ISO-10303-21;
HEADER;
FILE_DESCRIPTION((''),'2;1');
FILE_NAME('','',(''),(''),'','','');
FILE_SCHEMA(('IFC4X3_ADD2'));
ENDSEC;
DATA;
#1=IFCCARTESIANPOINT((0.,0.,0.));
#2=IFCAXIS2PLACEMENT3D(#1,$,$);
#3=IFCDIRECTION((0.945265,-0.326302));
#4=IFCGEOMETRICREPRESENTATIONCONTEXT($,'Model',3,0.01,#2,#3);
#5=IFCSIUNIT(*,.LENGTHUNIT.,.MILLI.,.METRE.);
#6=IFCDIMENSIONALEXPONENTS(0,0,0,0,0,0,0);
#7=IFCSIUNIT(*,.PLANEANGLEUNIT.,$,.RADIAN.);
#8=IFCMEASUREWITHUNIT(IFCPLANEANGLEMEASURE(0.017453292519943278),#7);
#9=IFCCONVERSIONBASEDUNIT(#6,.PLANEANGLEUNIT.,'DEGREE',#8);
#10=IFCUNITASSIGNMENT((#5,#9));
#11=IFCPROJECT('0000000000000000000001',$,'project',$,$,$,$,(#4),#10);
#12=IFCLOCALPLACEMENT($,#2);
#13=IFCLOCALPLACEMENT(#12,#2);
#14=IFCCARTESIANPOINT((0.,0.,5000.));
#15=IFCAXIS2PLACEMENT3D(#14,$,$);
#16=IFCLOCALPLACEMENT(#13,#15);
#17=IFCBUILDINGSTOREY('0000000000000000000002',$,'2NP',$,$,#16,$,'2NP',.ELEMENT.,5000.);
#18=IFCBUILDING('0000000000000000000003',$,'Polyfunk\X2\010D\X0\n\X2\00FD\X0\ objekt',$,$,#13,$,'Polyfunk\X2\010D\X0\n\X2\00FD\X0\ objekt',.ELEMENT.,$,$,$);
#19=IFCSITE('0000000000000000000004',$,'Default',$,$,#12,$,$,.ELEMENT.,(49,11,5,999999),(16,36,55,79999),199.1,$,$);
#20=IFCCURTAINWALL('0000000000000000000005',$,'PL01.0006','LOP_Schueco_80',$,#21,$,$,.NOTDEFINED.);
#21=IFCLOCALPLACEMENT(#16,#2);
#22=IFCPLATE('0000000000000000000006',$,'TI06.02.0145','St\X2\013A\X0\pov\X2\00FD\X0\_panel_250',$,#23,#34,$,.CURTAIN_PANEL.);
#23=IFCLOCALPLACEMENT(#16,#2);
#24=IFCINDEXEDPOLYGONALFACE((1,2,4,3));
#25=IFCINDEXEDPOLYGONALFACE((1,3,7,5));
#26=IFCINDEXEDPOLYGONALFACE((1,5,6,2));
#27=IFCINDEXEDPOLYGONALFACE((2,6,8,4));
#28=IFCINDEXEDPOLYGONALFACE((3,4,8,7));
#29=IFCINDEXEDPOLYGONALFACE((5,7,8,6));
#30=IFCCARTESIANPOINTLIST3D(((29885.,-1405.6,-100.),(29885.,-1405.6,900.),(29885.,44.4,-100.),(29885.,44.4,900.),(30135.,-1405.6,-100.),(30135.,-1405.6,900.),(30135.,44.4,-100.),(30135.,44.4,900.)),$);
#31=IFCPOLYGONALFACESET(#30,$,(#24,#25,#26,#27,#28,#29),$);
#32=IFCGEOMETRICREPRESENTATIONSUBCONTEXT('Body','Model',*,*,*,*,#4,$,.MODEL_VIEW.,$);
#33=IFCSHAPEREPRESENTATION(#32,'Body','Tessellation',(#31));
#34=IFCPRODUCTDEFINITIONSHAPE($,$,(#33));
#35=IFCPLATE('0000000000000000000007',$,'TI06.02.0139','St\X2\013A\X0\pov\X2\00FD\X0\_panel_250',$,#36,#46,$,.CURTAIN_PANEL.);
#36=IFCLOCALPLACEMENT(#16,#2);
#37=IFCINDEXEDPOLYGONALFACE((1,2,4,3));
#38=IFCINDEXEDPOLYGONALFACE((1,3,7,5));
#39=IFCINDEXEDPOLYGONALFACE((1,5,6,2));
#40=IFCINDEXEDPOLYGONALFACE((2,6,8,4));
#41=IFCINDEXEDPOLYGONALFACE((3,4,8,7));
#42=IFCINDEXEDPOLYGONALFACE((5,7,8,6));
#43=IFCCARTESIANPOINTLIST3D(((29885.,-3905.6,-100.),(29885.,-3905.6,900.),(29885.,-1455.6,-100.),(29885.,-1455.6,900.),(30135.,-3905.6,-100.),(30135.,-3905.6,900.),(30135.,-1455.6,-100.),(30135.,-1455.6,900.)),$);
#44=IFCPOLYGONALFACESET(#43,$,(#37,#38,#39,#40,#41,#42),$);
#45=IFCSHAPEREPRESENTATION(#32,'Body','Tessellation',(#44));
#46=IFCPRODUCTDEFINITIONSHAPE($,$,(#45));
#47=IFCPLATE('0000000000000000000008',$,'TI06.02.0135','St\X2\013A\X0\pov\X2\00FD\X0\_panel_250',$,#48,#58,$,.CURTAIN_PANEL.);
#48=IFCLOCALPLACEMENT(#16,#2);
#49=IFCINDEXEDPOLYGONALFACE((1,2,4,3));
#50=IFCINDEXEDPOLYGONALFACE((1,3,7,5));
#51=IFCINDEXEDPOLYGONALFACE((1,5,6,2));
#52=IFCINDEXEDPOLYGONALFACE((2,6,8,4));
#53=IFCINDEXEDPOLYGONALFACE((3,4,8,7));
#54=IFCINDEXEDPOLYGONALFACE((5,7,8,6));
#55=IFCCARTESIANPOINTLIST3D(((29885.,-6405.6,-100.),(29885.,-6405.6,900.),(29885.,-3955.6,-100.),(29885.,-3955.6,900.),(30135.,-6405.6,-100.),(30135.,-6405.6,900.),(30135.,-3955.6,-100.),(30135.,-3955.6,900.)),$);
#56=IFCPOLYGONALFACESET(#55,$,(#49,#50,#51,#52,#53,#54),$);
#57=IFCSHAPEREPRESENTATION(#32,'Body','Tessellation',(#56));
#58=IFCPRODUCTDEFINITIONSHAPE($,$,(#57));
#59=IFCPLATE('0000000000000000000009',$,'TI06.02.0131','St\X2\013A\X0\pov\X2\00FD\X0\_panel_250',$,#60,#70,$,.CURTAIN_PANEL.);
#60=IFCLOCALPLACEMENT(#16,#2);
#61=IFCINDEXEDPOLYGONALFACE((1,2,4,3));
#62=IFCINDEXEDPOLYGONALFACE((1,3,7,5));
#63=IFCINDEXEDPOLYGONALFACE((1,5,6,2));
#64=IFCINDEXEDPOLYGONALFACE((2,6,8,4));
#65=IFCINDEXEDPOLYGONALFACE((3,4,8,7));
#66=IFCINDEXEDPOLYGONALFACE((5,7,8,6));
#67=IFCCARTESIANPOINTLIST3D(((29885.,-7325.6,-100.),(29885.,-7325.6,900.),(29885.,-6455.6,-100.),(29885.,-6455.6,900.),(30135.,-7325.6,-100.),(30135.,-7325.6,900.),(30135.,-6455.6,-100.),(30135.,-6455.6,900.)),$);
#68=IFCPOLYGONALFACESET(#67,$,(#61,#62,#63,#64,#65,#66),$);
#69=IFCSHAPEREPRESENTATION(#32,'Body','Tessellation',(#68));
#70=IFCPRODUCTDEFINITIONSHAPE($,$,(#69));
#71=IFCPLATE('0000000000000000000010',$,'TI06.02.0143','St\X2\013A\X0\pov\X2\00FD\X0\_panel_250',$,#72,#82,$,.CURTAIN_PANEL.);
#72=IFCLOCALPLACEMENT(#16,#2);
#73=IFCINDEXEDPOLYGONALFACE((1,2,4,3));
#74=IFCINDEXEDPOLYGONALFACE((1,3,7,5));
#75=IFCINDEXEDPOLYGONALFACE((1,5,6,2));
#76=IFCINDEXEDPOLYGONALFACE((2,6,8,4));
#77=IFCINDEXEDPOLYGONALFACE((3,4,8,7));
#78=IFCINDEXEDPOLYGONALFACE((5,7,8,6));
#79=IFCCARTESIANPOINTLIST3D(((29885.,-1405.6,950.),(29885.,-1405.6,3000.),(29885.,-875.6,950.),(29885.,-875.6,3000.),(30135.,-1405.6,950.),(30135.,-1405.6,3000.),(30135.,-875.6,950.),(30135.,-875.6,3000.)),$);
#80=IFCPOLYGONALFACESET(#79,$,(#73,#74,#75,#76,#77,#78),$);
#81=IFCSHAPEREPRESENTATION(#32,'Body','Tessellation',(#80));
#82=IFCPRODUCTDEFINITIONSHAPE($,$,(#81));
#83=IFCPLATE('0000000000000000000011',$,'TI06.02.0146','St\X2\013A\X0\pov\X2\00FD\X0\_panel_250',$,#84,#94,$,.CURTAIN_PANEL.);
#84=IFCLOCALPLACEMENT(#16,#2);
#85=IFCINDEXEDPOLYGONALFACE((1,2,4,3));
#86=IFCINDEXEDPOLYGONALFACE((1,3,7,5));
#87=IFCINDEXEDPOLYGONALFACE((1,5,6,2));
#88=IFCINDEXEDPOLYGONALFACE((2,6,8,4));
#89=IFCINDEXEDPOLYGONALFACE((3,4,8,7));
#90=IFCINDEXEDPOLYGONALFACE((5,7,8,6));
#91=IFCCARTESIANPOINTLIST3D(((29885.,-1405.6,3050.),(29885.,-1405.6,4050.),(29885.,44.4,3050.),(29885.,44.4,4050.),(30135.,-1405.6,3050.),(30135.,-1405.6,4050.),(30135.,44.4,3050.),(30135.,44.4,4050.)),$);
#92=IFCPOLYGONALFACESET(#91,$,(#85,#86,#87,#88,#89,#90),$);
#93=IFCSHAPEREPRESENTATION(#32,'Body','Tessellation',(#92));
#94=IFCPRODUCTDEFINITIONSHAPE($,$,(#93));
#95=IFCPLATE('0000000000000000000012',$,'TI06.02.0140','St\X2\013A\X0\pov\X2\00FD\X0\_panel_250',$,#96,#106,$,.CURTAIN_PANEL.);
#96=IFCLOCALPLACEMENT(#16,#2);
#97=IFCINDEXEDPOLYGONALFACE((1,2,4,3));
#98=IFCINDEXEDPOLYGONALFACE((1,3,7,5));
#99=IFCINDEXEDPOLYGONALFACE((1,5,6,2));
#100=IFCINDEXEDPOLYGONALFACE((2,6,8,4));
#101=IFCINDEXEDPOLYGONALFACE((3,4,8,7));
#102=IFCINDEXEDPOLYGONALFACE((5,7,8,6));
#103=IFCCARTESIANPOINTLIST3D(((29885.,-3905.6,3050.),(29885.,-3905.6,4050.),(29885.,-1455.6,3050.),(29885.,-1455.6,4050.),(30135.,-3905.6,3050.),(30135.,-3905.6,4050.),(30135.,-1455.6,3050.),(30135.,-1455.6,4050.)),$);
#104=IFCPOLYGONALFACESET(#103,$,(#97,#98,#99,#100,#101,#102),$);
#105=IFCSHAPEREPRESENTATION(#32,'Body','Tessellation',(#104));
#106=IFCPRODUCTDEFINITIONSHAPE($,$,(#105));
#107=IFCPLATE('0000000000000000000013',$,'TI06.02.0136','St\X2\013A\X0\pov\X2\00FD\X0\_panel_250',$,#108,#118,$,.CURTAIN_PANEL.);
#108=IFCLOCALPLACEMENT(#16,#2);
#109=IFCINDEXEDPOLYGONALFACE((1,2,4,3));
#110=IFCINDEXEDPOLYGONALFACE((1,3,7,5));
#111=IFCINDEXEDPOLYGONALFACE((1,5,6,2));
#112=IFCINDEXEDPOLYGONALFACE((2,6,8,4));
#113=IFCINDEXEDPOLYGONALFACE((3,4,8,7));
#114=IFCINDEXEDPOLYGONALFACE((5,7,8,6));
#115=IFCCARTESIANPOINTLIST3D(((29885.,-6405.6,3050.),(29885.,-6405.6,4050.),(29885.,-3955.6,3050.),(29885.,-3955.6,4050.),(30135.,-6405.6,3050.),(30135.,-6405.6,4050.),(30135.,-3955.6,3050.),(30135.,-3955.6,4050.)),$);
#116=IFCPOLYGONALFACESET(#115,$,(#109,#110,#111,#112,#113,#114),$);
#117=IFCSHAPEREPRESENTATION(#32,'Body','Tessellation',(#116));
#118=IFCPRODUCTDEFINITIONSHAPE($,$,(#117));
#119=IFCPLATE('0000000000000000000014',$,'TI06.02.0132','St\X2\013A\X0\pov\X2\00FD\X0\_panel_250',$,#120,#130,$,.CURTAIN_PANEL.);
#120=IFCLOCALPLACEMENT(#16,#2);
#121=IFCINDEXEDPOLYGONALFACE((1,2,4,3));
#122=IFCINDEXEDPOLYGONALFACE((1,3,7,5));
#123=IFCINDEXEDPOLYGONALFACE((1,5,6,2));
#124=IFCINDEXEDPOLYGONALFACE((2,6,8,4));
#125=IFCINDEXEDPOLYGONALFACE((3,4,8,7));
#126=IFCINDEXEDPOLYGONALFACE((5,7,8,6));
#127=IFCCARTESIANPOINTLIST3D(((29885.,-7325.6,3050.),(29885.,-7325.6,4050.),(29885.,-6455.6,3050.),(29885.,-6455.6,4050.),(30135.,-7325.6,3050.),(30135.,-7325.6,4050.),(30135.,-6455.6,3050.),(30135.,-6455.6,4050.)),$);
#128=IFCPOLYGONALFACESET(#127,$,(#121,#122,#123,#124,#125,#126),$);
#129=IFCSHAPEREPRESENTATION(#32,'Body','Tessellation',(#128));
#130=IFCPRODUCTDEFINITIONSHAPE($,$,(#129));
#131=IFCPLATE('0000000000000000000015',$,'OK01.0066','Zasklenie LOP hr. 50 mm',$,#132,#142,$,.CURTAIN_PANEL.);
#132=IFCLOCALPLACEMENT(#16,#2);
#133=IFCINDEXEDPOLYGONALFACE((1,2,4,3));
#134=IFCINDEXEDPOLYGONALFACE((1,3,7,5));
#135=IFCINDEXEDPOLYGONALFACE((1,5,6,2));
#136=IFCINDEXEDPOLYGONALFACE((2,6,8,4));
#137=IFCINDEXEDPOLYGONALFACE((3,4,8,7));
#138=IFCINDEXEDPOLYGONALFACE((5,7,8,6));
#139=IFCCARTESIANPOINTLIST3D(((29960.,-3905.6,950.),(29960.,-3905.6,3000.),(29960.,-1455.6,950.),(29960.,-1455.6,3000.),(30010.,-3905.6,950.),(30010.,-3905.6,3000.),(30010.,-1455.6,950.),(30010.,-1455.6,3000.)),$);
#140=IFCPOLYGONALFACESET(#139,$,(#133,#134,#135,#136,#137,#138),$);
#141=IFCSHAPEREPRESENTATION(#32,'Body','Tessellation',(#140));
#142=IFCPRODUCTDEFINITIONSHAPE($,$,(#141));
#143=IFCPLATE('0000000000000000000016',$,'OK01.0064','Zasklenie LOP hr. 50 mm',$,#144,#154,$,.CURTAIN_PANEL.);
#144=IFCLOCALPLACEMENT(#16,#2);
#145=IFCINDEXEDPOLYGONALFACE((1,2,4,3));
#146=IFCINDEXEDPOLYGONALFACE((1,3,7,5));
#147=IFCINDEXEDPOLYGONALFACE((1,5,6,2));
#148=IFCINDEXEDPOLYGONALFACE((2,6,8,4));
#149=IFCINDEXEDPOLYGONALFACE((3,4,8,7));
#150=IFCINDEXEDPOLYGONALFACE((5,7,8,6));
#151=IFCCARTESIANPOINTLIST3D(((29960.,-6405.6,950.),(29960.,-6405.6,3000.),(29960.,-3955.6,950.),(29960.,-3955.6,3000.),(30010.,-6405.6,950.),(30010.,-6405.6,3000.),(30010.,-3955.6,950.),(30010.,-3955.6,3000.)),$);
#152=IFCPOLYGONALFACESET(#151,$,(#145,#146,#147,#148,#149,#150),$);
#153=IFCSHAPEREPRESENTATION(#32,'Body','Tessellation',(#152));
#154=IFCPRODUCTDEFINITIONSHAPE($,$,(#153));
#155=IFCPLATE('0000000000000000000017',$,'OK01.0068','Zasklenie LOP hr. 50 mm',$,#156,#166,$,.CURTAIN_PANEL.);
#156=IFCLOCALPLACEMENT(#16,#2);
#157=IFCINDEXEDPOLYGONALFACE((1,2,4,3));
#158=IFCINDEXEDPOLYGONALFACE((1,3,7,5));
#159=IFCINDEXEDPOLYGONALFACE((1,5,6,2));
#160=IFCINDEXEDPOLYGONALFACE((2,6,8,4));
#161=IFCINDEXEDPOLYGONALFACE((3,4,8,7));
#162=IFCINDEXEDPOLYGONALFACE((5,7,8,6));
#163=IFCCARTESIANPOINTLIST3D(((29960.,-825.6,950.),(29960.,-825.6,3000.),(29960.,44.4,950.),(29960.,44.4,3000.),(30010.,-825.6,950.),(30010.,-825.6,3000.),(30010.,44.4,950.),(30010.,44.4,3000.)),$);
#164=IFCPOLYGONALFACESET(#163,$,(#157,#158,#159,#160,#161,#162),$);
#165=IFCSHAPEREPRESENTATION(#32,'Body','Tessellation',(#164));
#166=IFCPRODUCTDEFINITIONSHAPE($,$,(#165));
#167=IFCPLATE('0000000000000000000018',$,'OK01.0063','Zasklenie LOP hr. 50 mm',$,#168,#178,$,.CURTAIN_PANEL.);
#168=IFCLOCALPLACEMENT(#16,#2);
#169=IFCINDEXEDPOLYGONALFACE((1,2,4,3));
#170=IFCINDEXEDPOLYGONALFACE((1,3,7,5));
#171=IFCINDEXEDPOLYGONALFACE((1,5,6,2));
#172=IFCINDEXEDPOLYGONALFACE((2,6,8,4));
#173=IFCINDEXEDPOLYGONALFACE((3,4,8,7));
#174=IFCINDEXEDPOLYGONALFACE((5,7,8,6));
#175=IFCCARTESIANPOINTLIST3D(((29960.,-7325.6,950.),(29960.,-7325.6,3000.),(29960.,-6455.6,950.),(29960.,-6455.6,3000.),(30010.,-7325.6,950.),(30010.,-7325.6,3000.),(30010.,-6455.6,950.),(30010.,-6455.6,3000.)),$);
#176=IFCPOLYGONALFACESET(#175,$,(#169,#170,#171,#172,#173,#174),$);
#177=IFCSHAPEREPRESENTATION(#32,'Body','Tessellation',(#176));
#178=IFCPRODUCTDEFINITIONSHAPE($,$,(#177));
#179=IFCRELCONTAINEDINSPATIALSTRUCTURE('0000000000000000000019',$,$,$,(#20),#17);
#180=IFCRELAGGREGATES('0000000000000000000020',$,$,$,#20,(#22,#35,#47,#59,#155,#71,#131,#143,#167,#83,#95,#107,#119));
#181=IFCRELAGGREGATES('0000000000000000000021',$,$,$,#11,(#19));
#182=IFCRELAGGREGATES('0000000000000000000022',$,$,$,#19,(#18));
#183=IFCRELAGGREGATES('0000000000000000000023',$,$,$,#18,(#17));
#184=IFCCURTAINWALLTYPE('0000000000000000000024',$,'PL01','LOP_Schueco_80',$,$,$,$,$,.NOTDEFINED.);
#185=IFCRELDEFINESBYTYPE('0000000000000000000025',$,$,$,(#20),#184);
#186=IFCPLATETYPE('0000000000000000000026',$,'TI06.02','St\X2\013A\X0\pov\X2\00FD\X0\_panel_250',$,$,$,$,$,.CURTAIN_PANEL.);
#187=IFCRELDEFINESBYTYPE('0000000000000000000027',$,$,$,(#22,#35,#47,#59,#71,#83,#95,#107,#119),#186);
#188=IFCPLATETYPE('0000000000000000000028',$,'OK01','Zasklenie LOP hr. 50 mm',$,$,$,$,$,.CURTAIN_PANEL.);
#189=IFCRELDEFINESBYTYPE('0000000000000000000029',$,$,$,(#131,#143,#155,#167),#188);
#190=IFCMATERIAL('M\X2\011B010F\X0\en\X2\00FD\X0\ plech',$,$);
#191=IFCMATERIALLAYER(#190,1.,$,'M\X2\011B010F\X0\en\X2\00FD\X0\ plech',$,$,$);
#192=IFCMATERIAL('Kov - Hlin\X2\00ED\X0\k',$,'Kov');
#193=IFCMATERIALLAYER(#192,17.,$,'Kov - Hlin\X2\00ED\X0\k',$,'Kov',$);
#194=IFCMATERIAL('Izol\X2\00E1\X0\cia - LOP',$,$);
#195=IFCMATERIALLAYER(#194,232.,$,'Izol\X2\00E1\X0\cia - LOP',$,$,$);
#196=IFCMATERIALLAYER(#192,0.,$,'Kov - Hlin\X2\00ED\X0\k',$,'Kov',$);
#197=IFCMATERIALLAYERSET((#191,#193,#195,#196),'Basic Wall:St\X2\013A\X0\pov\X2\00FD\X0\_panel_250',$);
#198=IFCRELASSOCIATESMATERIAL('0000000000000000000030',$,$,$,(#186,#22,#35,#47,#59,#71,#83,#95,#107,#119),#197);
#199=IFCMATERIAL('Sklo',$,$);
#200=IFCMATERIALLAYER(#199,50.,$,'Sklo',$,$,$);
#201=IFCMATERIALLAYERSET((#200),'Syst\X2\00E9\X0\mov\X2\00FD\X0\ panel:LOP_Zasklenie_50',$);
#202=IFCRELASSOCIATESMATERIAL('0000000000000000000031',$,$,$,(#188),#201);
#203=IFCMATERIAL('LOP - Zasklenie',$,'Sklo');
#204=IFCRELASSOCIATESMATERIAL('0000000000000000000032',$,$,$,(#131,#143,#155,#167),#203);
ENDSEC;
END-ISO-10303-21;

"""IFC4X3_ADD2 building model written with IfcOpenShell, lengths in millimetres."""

from ifc_helpers import new_model, entity, si_unit, converted_unit, direction, frame, frame_2d, origin, origin_2d_with_axis, place, context, subcontext, project, spatial, rectangle, extrude, source, transform, mapped, material, layer, layer_set, layer_usage, type_object, type_shapes, element, aggregate, save


model = new_model("IFC4X3_ADD2")

# Units and contexts
model_context = context("Model", 3, precision=0.01, world=origin(), true_north=direction((0.945265, -0.326302)))
body_context = subcontext(model_context, "Body", "Model", "MODEL_VIEW")
ifc_project = project(units=[si_unit("LENGTHUNIT", "METRE", prefix="MILLI"), converted_unit("PLANEANGLEUNIT", "DEGREE", entity("IfcPlaneAngleMeasure", 0.017453292519943278), si_unit("PLANEANGLEUNIT", "RADIAN"), dimensions=[0, 0, 0, 0, 0, 0, 0])], contexts=[model_context])

# Site, building, storey
site_placement = place(None, origin())
site = spatial("IfcSite", under=ifc_project, at=site_placement, Name="Default", CompositionType="ELEMENT", RefLatitude=(49, 11, 5, 999999), RefLongitude=(16, 36, 55, 79999), RefElevation=199.1)
building_placement = place(site_placement, origin())
building = spatial("IfcBuilding", under=site, at=building_placement, Name="Polyfunkčný objekt", LongName="Polyfunkčný objekt", CompositionType="ELEMENT")
storey_placement = place(building_placement, frame((0.0, 0.0, 5000.0)))
storey = spatial("IfcBuildingStorey", under=building, at=storey_placement, Name="2NP", LongName="2NP", CompositionType="ELEMENT", Elevation=5000.0)

# Curtain wall, plates
curtain_wall_type = type_object("IfcCurtainWallType", Name="PL01", Description="LOP_Schueco_80", PredefinedType="NOTDEFINED")
curtain_wall_placement = place(storey_placement, frame((0.0, 0.0, -5000.0)))
curtain_wall = element("IfcCurtainWall", 1, at=curtain_wall_placement, inside=storey, type_object=curtain_wall_type, Name="PL01.0006", Description="LOP_Schueco_80", PredefinedType="NOTDEFINED")
ifc_material_1 = material(Name="Měďený plech")
ifc_layer_1 = layer(ifc_material_1, 1.0, Name="Měďený plech")
ifc_material_2 = material(Name="Kov - Hliník", Category="Kov")
ifc_layer_2 = layer(ifc_material_2, 17.0, Name="Kov - Hliník", Category="Kov")
ifc_material_3 = material(Name="Izolácia - LOP")
ifc_layer_3 = layer(ifc_material_3, 232.0, Name="Izolácia - LOP")
ifc_layer_4 = layer(ifc_material_2, 0.0, Name="Kov - Hliník", Category="Kov")
ifc_layer_set_1 = layer_set([ifc_layer_1, ifc_layer_2, ifc_layer_3, ifc_layer_4], Name="Basic Wall:Stĺpový_panel_250")
ifc_layer_usage_1 = layer_usage(ifc_layer_set_1, "AXIS2", "POSITIVE", -125.0)
plate_type_1 = type_object("IfcPlateType", Name="TI06.02", Description="Stĺpový_panel_250", PredefinedType="CURTAIN_PANEL", material=ifc_layer_set_1)
plate_1_placement = place(storey_placement, frame((30010.0, 44.4, -100.0), z_axis=(0.0, 0.0, 1.0), x_axis=(0.0, -1.0, 0.0)))
plate_1 = element("IfcPlate", 2, at=plate_1_placement, type_object=plate_type_1, material=ifc_layer_usage_1, Name="TI06.02.0145", Description="Stĺpový_panel_250", PredefinedType="CURTAIN_PANEL", context=body_context, shape_type="SweptSolid", body=[
    extrude(rectangle(XDim=250.0, YDim=1450.0, at=frame_2d((0.0, 0.0), x_axis=(1.0, 0.0))), frame((725.0, 0.0, 0.0), z_axis=(0.0, 0.0, 1.0), x_axis=(0.0, 1.0, 0.0)), (0.0, 0.0, 1.0), 1000.0),
])
ifc_layer_usage_2 = layer_usage(ifc_layer_set_1, "AXIS2", "POSITIVE", -125.0)
plate_2_placement = place(storey_placement, frame((30010.0, -1455.6, -100.0), z_axis=(0.0, 0.0, 1.0), x_axis=(0.0, -1.0, 0.0)))
plate_2 = element("IfcPlate", 3, at=plate_2_placement, type_object=plate_type_1, material=ifc_layer_usage_2, Name="TI06.02.0139", Description="Stĺpový_panel_250", PredefinedType="CURTAIN_PANEL", context=body_context, shape_type="SweptSolid", body=[
    extrude(rectangle(XDim=250.0, YDim=2450.0, at=origin_2d_with_axis()), frame((1225.0, 0.0, 0.0), z_axis=(0.0, 0.0, 1.0), x_axis=(0.0, 1.0, 0.0)), (0.0, 0.0, 1.0), 1000.0),
])
ifc_layer_usage_3 = layer_usage(ifc_layer_set_1, "AXIS2", "POSITIVE", -125.0)
plate_3_placement = place(storey_placement, frame((30010.0, -3955.6, -100.0), z_axis=(0.0, 0.0, 1.0), x_axis=(0.0, -1.0, 0.0)))
plate_3 = element("IfcPlate", 4, at=plate_3_placement, type_object=plate_type_1, material=ifc_layer_usage_3, Name="TI06.02.0135", Description="Stĺpový_panel_250", PredefinedType="CURTAIN_PANEL", context=body_context, shape_type="SweptSolid", body=[
    extrude(rectangle(XDim=250.0, YDim=2450.0, at=frame_2d((0.0, 0.0), x_axis=(1.0, 0.0))), frame((1225.0, 0.0, 0.0), z_axis=(0.0, 0.0, 1.0), x_axis=(0.0, 1.0, 0.0)), (0.0, 0.0, 1.0), 1000.0),
])
ifc_layer_usage_4 = layer_usage(ifc_layer_set_1, "AXIS2", "POSITIVE", -125.0)
plate_4_placement = place(storey_placement, frame((30010.0, -6455.6, -100.0), z_axis=(0.0, 0.0, 1.0), x_axis=(0.0, -1.0, 0.0)))
plate_4 = element("IfcPlate", 5, at=plate_4_placement, type_object=plate_type_1, material=ifc_layer_usage_4, Name="TI06.02.0131", Description="Stĺpový_panel_250", PredefinedType="CURTAIN_PANEL", context=body_context, shape_type="SweptSolid", body=[
    extrude(rectangle(XDim=250.0, YDim=870.0, at=frame_2d((0.0, 0.0), x_axis=(1.0, 0.0))), frame((435.0, 0.0, 0.0), z_axis=(0.0, 0.0, 1.0), x_axis=(0.0, 1.0, 0.0)), (0.0, 0.0, 1.0), 1000.0),
])
ifc_layer_usage_5 = layer_usage(ifc_layer_set_1, "AXIS2", "POSITIVE", -125.0)
plate_5_placement = place(storey_placement, frame((30010.0, -875.6, 950.0), z_axis=(0.0, 0.0, 1.0), x_axis=(0.0, -1.0, 0.0)))
plate_5 = element("IfcPlate", 6, at=plate_5_placement, type_object=plate_type_1, material=ifc_layer_usage_5, Name="TI06.02.0143", Description="Stĺpový_panel_250", PredefinedType="CURTAIN_PANEL", context=body_context, shape_type="SweptSolid", body=[
    extrude(rectangle(XDim=250.0, YDim=530.0, at=frame_2d((0.0, 0.0), x_axis=(1.0, 0.0))), frame((265.0, 0.0, 0.0), z_axis=(0.0, 0.0, 1.0), x_axis=(0.0, 1.0, 0.0)), (0.0, 0.0, 1.0), 2050.0),
])
ifc_layer_usage_6 = layer_usage(ifc_layer_set_1, "AXIS2", "POSITIVE", -125.0)
plate_6_placement = place(storey_placement, frame((30010.0, 44.4, 3050.0), z_axis=(0.0, 0.0, 1.0), x_axis=(0.0, -1.0, 0.0)))
plate_6 = element("IfcPlate", 7, at=plate_6_placement, type_object=plate_type_1, material=ifc_layer_usage_6, Name="TI06.02.0146", Description="Stĺpový_panel_250", PredefinedType="CURTAIN_PANEL", context=body_context, shape_type="SweptSolid", body=[
    extrude(rectangle(XDim=250.0, YDim=1450.0, at=frame_2d((0.0, 0.0), x_axis=(1.0, 0.0))), frame((725.0, 0.0, 0.0), z_axis=(0.0, 0.0, 1.0), x_axis=(0.0, 1.0, 0.0)), (0.0, 0.0, 1.0), 1000.0),
])
ifc_layer_usage_7 = layer_usage(ifc_layer_set_1, "AXIS2", "POSITIVE", -125.0)
plate_7_placement = place(storey_placement, frame((30010.0, -1455.6, 3050.0), z_axis=(0.0, 0.0, 1.0), x_axis=(0.0, -1.0, 0.0)))
plate_7 = element("IfcPlate", 8, at=plate_7_placement, type_object=plate_type_1, material=ifc_layer_usage_7, Name="TI06.02.0140", Description="Stĺpový_panel_250", PredefinedType="CURTAIN_PANEL", context=body_context, shape_type="SweptSolid", body=[
    extrude(rectangle(XDim=250.0, YDim=2450.0, at=origin_2d_with_axis()), frame((1225.0, 0.0, 0.0), z_axis=(0.0, 0.0, 1.0), x_axis=(0.0, 1.0, 0.0)), (0.0, 0.0, 1.0), 1000.0),
])
ifc_layer_usage_8 = layer_usage(ifc_layer_set_1, "AXIS2", "POSITIVE", -125.0)
plate_8_placement = place(storey_placement, frame((30010.0, -3955.6, 3050.0), z_axis=(0.0, 0.0, 1.0), x_axis=(0.0, -1.0, 0.0)))
plate_8 = element("IfcPlate", 9, at=plate_8_placement, type_object=plate_type_1, material=ifc_layer_usage_8, Name="TI06.02.0136", Description="Stĺpový_panel_250", PredefinedType="CURTAIN_PANEL", context=body_context, shape_type="SweptSolid", body=[
    extrude(rectangle(XDim=250.0, YDim=2450.0, at=frame_2d((0.0, 0.0), x_axis=(1.0, 0.0))), frame((1225.0, 0.0, 0.0), z_axis=(0.0, 0.0, 1.0), x_axis=(0.0, 1.0, 0.0)), (0.0, 0.0, 1.0), 1000.0),
])
ifc_layer_usage_9 = layer_usage(ifc_layer_set_1, "AXIS2", "POSITIVE", -125.0)
plate_9_placement = place(storey_placement, frame((30010.0, -6455.6, 3050.0), z_axis=(0.0, 0.0, 1.0), x_axis=(0.0, -1.0, 0.0)))
plate_9 = element("IfcPlate", 10, at=plate_9_placement, type_object=plate_type_1, material=ifc_layer_usage_9, Name="TI06.02.0132", Description="Stĺpový_panel_250", PredefinedType="CURTAIN_PANEL", context=body_context, shape_type="SweptSolid", body=[
    extrude(rectangle(XDim=250.0, YDim=870.0, at=frame_2d((0.0, 0.0), x_axis=(1.0, 0.0))), frame((435.0, 0.0, 0.0), z_axis=(0.0, 0.0, 1.0), x_axis=(0.0, 1.0, 0.0)), (0.0, 0.0, 1.0), 1000.0),
])
ifc_material_4 = material(Name="LOP - Zasklenie", Category="Sklo")
ifc_material_5 = material(Name="Sklo")
ifc_layer_5 = layer(ifc_material_5, 50.0, Name="Sklo")
ifc_layer_set_2 = layer_set([ifc_layer_5], Name="Systémový panel:LOP_Zasklenie_50")
plate_type_2 = type_object("IfcPlateType", Name="OK01", Description="Zasklenie LOP hr. 50 mm", PredefinedType="CURTAIN_PANEL", material=ifc_layer_set_2)
shared_shape_1 = source(origin(), body_context, "Body", "SweptSolid", [
    extrude(rectangle(XDim=50.0, YDim=2450.0, at=origin_2d_with_axis()), frame((0.0, -25.0, 0.0), z_axis=(0.0, 0.0, 1.0), x_axis=(0.0, 1.0, 0.0)), (0.0, 0.0, 1.0), 2050.0),
])
plate_10_placement = place(curtain_wall_placement, frame((30010.0, -2680.6, 5950.0), z_axis=(0.0, 0.0, 1.0), x_axis=(0.0, -1.0, 0.0)))
plate_10 = element("IfcPlate", 11, at=plate_10_placement, type_object=plate_type_2, material=ifc_material_4, Name="OK01.0066", Description="Zasklenie LOP hr. 50 mm", PredefinedType="CURTAIN_PANEL", context=body_context, shape_type="MappedRepresentation", body=[
    mapped(shared_shape_1, transform((0.0, 0.0, 0.0), scale=1.0)),
])
plate_11_placement = place(curtain_wall_placement, frame((30010.0, -5180.6, 5950.0), z_axis=(0.0, 0.0, 1.0), x_axis=(0.0, -1.0, 0.0)))
plate_11 = element("IfcPlate", 12, at=plate_11_placement, type_object=plate_type_2, material=ifc_material_4, Name="OK01.0064", Description="Zasklenie LOP hr. 50 mm", PredefinedType="CURTAIN_PANEL", context=body_context, shape_type="MappedRepresentation", body=[
    mapped(shared_shape_1, transform((0.0, 0.0, 0.0), scale=1.0)),
])
shared_shape_2 = source(origin(), body_context, "Body", "SweptSolid", [
    extrude(rectangle(XDim=50.0, YDim=870.0, at=origin_2d_with_axis()), frame((0.0, -25.0, 0.0), z_axis=(0.0, 0.0, 1.0), x_axis=(0.0, 1.0, 0.0)), (0.0, 0.0, 1.0), 2050.0),
])
type_shapes(plate_type_2, [shared_shape_1, shared_shape_2])
plate_12_placement = place(curtain_wall_placement, frame((30010.0, -390.6, 5950.0), z_axis=(0.0, 0.0, 1.0), x_axis=(0.0, -1.0, 0.0)))
plate_12 = element("IfcPlate", 13, at=plate_12_placement, type_object=plate_type_2, material=ifc_material_4, Name="OK01.0068", Description="Zasklenie LOP hr. 50 mm", PredefinedType="CURTAIN_PANEL", context=body_context, shape_type="MappedRepresentation", body=[
    mapped(shared_shape_2, transform((0.0, 0.0, 0.0), scale=1.0)),
])
plate_13_placement = place(curtain_wall_placement, frame((30010.0, -6890.6, 5950.0), z_axis=(0.0, 0.0, 1.0), x_axis=(0.0, -1.0, 0.0)))
plate_13 = element("IfcPlate", 14, at=plate_13_placement, type_object=plate_type_2, material=ifc_material_4, Name="OK01.0063", Description="Zasklenie LOP hr. 50 mm", PredefinedType="CURTAIN_PANEL", context=body_context, shape_type="MappedRepresentation", body=[
    mapped(shared_shape_2, transform((0.0, 0.0, 0.0), scale=1.0)),
])
aggregate(curtain_wall, [plate_1, plate_2, plate_3, plate_4, plate_12, plate_5, plate_10, plate_11, plate_13, plate_6, plate_7, plate_8, plate_9])

save(model, "model.ifc")
